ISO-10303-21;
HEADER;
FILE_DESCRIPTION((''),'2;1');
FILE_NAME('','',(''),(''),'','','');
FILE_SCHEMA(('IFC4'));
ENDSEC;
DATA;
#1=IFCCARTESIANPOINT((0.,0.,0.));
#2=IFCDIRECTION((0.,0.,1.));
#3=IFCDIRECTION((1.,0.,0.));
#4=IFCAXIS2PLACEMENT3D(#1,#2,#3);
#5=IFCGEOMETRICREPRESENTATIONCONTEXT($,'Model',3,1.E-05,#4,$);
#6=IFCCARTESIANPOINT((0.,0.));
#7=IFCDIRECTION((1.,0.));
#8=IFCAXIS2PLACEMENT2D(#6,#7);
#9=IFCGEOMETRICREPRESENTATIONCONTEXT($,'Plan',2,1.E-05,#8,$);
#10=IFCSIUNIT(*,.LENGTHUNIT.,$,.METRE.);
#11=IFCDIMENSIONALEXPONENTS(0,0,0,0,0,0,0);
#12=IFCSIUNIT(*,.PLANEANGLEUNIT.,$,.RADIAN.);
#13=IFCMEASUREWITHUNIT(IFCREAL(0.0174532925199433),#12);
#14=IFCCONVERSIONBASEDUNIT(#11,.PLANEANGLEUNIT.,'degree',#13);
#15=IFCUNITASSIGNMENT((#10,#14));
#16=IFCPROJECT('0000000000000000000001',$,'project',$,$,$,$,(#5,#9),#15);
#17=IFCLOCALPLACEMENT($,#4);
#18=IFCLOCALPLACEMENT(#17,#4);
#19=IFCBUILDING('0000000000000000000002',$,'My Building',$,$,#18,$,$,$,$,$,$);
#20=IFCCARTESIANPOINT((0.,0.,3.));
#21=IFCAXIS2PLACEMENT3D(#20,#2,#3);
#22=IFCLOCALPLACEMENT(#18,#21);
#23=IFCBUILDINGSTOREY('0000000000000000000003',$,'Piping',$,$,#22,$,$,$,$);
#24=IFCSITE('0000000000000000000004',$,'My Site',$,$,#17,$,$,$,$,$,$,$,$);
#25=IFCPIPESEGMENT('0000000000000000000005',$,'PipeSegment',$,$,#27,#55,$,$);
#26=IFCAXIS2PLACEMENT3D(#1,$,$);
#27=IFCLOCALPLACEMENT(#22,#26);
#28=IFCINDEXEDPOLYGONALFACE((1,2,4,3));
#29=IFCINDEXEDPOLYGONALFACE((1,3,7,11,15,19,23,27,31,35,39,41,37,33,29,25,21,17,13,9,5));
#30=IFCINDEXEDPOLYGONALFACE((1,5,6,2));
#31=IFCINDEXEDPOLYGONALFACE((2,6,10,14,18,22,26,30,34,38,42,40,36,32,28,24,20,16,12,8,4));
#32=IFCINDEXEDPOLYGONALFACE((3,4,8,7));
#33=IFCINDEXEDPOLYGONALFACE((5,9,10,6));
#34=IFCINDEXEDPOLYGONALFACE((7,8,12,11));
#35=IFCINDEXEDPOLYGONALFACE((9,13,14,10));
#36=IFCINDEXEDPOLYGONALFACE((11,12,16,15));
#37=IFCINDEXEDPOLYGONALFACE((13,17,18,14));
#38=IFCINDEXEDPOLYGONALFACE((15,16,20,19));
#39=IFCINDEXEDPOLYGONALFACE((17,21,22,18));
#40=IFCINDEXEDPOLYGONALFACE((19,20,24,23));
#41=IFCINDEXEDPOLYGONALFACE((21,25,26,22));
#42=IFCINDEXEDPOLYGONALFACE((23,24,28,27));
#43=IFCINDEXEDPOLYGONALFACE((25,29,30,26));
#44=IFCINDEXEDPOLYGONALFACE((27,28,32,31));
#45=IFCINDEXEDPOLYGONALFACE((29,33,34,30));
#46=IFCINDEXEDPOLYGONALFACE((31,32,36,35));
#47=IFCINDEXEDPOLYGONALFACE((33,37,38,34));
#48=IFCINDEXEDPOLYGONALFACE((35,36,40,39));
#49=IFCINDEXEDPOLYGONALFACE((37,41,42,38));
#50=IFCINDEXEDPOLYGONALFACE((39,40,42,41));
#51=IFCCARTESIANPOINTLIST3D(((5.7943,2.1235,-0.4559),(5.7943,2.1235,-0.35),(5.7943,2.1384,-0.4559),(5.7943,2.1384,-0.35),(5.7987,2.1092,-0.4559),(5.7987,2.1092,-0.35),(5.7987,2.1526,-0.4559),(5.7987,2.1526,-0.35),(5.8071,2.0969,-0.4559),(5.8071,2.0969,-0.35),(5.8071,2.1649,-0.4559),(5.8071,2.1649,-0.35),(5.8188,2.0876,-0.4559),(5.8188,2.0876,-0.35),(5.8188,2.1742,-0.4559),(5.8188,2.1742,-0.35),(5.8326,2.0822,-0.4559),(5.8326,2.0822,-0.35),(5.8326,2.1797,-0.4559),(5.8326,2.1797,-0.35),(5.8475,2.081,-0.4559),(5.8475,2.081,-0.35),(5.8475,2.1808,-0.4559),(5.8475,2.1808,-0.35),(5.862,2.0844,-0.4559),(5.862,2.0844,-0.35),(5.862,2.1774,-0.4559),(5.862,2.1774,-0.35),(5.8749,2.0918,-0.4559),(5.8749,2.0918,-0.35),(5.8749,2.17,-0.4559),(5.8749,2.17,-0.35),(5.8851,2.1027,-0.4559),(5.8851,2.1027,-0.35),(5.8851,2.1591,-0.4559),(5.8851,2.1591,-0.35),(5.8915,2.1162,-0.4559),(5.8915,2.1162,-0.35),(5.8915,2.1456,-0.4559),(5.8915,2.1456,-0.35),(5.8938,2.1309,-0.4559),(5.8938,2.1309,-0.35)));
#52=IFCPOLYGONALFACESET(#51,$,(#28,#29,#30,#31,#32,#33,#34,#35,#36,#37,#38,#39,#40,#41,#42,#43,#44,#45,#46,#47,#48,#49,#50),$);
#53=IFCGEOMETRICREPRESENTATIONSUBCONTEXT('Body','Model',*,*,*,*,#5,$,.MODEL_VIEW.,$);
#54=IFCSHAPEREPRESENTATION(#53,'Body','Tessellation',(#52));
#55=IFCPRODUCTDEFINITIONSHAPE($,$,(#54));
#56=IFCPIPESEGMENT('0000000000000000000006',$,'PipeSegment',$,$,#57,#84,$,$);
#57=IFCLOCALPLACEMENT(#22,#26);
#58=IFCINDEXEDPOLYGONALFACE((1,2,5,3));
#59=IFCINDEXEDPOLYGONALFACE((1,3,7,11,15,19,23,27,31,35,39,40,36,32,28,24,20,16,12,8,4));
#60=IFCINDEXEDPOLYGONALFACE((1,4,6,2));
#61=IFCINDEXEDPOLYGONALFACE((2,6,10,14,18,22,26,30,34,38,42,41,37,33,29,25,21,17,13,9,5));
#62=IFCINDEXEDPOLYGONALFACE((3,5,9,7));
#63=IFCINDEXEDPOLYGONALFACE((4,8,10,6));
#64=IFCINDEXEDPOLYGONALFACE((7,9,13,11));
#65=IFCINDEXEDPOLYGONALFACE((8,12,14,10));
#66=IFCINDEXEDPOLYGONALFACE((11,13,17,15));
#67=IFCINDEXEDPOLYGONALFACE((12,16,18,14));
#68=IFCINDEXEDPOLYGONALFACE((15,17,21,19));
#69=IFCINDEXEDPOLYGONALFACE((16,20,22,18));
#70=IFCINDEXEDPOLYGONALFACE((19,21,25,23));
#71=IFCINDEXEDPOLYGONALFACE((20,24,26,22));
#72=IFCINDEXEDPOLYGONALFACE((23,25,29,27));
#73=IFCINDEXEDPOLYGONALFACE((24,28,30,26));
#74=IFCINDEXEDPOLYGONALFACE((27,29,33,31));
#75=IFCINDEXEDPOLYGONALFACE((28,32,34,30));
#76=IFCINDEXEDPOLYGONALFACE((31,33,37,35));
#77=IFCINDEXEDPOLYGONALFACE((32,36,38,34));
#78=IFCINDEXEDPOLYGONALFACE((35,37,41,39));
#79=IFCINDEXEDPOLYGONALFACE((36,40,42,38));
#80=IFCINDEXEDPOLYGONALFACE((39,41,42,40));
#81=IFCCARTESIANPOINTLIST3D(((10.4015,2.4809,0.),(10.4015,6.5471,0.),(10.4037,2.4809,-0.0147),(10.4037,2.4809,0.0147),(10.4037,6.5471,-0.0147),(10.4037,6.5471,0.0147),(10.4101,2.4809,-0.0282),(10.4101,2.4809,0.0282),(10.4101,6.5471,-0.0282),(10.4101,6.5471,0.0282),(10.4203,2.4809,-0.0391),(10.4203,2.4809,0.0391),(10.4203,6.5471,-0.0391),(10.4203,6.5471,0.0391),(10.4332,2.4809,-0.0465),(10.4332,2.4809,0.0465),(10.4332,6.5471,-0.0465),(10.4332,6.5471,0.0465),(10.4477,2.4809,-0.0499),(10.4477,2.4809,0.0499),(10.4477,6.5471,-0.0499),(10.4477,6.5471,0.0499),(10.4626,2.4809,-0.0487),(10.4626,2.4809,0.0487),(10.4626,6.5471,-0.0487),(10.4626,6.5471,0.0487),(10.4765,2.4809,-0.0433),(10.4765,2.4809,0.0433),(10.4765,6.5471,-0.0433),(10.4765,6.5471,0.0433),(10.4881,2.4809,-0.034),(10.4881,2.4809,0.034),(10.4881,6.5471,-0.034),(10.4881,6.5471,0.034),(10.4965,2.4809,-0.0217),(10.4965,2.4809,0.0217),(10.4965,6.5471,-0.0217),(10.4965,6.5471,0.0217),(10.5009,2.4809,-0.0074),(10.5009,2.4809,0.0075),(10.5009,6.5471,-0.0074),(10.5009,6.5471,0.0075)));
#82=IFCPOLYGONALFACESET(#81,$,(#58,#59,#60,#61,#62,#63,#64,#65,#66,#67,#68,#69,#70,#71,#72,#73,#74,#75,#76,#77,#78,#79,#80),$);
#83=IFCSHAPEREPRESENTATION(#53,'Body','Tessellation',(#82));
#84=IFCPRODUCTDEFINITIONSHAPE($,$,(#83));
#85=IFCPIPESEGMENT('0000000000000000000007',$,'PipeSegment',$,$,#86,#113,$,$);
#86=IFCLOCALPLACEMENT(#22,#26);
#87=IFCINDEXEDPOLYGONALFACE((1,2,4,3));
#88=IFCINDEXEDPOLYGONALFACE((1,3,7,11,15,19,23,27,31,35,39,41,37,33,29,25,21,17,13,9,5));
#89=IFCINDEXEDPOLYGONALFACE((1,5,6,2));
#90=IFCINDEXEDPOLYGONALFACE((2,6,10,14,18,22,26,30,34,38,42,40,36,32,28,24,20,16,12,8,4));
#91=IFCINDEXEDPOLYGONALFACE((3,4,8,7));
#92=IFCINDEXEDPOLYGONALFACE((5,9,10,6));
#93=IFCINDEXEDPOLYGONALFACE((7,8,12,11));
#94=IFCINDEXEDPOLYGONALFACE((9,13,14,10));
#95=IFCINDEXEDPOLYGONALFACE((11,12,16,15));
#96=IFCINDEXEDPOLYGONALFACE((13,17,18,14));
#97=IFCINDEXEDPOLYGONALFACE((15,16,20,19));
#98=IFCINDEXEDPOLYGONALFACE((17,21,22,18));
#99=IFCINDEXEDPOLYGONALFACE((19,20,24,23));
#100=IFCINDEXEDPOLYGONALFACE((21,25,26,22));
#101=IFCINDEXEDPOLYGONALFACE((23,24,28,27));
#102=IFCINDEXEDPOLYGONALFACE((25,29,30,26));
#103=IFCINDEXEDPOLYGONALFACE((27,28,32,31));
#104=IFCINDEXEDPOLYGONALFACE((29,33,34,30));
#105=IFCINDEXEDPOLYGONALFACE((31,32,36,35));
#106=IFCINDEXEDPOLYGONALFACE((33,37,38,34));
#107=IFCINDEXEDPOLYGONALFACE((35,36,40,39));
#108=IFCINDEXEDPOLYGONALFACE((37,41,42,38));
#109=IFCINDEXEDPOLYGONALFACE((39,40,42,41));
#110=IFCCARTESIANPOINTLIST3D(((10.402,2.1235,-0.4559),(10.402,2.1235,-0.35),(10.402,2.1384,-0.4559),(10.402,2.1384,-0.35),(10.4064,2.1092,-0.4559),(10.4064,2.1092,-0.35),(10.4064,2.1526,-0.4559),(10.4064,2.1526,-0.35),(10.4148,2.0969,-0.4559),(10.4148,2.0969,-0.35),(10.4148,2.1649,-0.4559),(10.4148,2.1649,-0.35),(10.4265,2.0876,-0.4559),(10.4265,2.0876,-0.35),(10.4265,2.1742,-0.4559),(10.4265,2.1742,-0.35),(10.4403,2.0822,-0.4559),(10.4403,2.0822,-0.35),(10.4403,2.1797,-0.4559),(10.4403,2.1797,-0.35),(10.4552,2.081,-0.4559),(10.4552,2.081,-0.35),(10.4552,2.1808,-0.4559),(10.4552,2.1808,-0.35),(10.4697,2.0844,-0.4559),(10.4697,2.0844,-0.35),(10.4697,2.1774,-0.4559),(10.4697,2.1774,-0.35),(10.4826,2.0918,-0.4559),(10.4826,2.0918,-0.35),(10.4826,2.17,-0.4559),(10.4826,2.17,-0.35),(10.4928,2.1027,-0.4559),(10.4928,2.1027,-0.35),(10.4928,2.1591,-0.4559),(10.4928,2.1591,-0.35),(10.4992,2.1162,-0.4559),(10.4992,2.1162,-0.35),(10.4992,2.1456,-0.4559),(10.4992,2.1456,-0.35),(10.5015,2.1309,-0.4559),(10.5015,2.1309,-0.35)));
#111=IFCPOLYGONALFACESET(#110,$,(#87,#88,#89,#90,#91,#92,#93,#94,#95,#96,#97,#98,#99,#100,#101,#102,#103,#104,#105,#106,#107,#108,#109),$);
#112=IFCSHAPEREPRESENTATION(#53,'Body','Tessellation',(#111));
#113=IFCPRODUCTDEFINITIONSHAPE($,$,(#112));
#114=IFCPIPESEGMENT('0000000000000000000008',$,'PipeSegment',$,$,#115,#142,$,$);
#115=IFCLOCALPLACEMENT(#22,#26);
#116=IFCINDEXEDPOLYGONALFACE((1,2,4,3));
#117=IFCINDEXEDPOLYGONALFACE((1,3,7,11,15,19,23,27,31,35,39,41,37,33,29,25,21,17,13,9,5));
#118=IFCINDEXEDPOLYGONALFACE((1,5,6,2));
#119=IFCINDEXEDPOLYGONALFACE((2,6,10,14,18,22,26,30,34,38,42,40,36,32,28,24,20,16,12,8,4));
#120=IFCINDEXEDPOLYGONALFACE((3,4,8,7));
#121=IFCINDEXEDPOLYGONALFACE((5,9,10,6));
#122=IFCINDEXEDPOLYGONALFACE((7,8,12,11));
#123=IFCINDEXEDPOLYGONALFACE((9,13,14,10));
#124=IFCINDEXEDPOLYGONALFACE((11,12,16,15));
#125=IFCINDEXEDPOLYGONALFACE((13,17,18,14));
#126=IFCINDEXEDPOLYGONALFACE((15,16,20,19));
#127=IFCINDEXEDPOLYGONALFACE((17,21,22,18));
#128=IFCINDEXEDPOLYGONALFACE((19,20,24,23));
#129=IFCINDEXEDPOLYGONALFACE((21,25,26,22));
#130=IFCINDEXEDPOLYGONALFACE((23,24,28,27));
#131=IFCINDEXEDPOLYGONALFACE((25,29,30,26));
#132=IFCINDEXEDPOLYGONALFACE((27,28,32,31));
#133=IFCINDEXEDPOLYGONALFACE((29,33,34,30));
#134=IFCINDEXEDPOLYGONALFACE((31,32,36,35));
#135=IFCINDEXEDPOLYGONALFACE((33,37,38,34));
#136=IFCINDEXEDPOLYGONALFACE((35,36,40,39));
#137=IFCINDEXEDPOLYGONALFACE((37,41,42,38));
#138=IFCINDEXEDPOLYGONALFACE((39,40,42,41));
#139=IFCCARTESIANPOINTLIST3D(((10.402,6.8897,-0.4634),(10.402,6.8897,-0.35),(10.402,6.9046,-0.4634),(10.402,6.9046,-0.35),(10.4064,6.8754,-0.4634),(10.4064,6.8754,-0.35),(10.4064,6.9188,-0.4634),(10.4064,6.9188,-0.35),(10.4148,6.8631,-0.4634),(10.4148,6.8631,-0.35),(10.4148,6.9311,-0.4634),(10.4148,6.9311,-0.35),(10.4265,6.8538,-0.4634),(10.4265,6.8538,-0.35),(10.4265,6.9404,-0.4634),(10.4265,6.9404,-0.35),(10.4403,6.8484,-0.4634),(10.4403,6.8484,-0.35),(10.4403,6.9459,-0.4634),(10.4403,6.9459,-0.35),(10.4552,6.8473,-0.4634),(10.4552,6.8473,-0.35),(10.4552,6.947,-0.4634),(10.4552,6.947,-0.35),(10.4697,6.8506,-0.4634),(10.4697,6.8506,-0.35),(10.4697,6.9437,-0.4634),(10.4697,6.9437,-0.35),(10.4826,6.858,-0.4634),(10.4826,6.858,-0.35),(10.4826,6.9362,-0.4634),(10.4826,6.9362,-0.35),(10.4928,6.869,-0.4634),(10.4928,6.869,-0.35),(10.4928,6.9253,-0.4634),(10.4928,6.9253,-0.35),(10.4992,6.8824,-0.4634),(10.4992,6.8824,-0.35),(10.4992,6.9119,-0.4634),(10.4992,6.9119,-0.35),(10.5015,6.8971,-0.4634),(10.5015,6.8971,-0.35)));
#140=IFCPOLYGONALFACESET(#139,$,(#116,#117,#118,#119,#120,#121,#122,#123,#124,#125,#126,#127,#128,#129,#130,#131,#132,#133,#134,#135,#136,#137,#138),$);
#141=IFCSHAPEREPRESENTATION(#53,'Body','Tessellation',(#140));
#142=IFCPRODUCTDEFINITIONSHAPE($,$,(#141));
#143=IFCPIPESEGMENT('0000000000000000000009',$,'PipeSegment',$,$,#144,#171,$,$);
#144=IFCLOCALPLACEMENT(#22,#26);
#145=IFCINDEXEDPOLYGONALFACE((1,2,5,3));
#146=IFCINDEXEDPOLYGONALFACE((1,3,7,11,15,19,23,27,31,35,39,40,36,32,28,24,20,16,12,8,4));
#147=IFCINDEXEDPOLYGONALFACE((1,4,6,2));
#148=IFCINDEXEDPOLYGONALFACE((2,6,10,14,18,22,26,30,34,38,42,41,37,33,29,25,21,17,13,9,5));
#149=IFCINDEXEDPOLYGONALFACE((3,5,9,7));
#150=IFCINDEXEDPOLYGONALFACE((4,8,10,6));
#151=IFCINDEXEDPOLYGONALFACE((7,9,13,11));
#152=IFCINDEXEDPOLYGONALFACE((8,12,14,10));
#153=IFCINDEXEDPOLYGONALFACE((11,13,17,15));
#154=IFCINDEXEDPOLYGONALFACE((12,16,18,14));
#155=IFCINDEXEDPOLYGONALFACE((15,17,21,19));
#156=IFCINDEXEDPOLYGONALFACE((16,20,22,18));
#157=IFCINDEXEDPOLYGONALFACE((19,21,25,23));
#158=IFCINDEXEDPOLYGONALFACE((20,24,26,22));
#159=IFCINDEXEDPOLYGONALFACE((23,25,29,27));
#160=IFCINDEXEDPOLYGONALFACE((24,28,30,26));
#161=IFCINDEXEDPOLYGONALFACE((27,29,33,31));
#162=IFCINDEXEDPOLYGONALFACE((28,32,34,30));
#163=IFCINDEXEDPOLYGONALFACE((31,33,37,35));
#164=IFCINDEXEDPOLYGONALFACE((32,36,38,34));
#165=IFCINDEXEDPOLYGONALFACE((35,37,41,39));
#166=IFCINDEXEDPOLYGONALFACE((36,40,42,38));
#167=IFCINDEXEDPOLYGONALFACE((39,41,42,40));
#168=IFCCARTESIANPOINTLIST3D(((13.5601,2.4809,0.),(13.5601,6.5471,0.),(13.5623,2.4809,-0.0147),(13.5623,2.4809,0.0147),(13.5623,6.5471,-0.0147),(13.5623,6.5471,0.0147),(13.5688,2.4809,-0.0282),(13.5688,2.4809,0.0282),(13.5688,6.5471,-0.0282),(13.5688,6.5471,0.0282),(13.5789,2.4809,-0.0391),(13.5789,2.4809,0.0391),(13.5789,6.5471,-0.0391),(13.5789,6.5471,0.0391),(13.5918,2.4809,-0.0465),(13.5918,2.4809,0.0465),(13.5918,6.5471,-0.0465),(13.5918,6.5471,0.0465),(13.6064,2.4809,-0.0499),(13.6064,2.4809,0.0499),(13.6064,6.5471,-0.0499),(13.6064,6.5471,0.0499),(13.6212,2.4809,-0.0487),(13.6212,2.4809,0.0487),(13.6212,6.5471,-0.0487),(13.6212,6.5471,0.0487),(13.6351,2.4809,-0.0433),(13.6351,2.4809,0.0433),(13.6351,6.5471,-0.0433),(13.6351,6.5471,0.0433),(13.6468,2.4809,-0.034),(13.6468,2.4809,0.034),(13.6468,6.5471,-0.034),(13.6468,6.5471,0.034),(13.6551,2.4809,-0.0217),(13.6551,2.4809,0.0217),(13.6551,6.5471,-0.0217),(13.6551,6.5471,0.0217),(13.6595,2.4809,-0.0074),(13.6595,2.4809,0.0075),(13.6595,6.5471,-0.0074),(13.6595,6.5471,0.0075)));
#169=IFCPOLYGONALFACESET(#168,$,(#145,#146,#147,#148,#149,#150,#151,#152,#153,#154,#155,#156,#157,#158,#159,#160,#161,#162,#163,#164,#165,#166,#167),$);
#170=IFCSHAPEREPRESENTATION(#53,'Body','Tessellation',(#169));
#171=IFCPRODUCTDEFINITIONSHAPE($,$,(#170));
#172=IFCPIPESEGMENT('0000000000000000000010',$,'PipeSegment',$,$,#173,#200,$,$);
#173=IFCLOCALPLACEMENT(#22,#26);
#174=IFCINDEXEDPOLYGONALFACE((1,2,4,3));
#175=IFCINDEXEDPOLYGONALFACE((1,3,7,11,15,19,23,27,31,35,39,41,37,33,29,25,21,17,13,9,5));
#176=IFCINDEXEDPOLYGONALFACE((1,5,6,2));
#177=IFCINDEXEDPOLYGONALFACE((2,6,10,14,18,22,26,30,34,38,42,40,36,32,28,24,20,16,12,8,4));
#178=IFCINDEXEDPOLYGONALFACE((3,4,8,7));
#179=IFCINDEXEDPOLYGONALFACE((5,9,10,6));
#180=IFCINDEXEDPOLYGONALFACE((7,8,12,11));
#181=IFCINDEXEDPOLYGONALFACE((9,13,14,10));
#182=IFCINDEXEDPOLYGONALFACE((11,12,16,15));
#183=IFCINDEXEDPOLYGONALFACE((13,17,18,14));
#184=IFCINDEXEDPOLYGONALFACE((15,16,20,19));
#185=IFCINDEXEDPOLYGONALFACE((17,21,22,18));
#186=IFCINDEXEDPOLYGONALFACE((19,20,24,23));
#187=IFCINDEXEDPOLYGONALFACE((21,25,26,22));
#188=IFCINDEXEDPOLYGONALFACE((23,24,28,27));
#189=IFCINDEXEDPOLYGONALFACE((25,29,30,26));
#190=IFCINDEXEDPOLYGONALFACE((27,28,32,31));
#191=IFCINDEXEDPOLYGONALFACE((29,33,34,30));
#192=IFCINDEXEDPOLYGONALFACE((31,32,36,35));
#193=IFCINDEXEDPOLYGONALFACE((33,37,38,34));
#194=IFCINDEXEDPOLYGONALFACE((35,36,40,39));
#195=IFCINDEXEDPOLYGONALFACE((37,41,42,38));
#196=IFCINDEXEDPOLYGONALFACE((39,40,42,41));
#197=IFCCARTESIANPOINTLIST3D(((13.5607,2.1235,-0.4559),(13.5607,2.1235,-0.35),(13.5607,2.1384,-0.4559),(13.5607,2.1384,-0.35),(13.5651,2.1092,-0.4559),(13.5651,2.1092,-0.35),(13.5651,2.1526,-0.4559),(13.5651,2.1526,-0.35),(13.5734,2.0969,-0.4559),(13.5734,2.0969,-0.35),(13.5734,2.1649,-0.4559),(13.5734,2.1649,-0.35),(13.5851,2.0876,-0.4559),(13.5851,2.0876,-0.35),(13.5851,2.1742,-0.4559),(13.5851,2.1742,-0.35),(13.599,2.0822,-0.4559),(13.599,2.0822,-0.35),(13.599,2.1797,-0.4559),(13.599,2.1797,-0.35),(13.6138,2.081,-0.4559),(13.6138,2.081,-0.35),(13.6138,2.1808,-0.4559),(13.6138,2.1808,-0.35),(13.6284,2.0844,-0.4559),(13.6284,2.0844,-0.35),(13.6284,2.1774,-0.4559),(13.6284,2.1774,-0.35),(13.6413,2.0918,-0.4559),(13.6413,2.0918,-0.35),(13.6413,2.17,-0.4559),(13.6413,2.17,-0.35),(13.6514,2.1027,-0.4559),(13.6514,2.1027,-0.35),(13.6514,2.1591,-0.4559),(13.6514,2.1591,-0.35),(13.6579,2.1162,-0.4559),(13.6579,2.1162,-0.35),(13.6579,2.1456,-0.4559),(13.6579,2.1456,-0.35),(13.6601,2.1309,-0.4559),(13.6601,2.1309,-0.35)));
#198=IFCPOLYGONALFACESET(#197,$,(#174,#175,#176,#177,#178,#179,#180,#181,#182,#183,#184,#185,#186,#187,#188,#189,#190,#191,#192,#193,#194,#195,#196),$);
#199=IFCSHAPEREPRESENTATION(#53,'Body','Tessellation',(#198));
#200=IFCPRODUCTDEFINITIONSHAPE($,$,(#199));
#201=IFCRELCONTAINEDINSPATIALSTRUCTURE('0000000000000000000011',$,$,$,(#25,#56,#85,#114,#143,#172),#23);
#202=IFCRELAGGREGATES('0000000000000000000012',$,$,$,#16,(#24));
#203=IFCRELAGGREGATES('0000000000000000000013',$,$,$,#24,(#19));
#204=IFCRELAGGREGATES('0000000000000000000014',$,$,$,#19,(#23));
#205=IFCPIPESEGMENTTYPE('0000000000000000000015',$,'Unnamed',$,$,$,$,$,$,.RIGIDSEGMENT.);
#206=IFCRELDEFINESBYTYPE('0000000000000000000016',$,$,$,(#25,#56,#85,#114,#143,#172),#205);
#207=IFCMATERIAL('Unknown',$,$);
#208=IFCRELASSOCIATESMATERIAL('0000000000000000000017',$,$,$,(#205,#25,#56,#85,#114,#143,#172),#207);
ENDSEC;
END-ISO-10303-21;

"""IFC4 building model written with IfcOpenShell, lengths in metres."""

from ifc_helpers import new_model, entity, si_unit, converted_unit, frame, origin_with_axes, origin_2d_with_axis, place, context, subcontext, project, spatial, circle, extrude, material, material_profile, profile_set, profile_usage, type_object, element, save


model = new_model("IFC4")

# Units and contexts
model_context = context("Model", 3, precision=1e-05, world=origin_with_axes())
plan_context = context("Plan", 2, precision=1e-05, world=origin_2d_with_axis())
body_context = subcontext(model_context, "Body", "Model", "MODEL_VIEW")
ifc_project = project(units=[si_unit("LENGTHUNIT", "METRE"), converted_unit("PLANEANGLEUNIT", "degree", entity("IfcReal", 0.0174532925199433), si_unit("PLANEANGLEUNIT", "RADIAN"), dimensions=[0, 0, 0, 0, 0, 0, 0])], contexts=[model_context, plan_context])

# Site, building, storey
site_placement = place(None, origin_with_axes())
site = spatial("IfcSite", under=ifc_project, at=site_placement, Name="My Site")
building_placement = place(site_placement, origin_with_axes())
building = spatial("IfcBuilding", under=site, at=building_placement, Name="My Building")
storey_placement = place(building_placement, frame((0.0, 0.0, 3.0), z_axis=(0.0, 0.0, 1.0), x_axis=(1.0, 0.0, 0.0)))
storey = spatial("IfcBuildingStorey", under=building, at=storey_placement, Name="Piping")

# Pipe segments
ifc_material = material(Name="Unknown")
ifc_material_profile = material_profile(ifc_material, circle(Radius=0.05))
ifc_profile_set = profile_set([ifc_material_profile])
pipe_segment_type = type_object("IfcPipeSegmentType", Name="Unnamed", PredefinedType="RIGIDSEGMENT", material=ifc_profile_set)
ifc_profile_usage_1 = profile_usage(ifc_profile_set, cardinal=5)
pipe_segment_1_placement = place(storey_placement, frame((5.8438, 2.1309, -0.35), z_axis=(0.0, 0.0, -1.0), x_axis=(1.0, 0.0, 0.0)))
element("IfcPipeSegment", 1, at=pipe_segment_1_placement, inside=storey, type_object=pipe_segment_type, material=ifc_profile_usage_1, Name="PipeSegment", context=body_context, shape_type="SweptSolid", body=[
    extrude(circle(Radius=0.05), origin_with_axes(), (0.0, 0.0, 1.0), 0.1059),
])
ifc_profile_usage_2 = profile_usage(ifc_profile_set, cardinal=5)
pipe_segment_2_placement = place(storey_placement, frame((10.4515, 2.4809, 0.0), z_axis=(0.0, 1.0, 0.0), x_axis=(-1.0, 0.0, 0.0)))
element("IfcPipeSegment", 2, at=pipe_segment_2_placement, inside=storey, type_object=pipe_segment_type, material=ifc_profile_usage_2, Name="PipeSegment", context=body_context, shape_type="SweptSolid", body=[
    extrude(circle(Radius=0.05), origin_with_axes(), (0.0, 0.0, 1.0), 4.0662),
])
ifc_profile_usage_3 = profile_usage(ifc_profile_set, cardinal=5)
pipe_segment_3_placement = place(storey_placement, frame((10.4515, 2.1309, -0.35), z_axis=(0.0, 0.0, -1.0), x_axis=(1.0, 0.0, 0.0)))
element("IfcPipeSegment", 3, at=pipe_segment_3_placement, inside=storey, type_object=pipe_segment_type, material=ifc_profile_usage_3, Name="PipeSegment", context=body_context, shape_type="SweptSolid", body=[
    extrude(circle(Radius=0.05), origin_with_axes(), (0.0, 0.0, 1.0), 0.1059),
])
ifc_profile_usage_4 = profile_usage(ifc_profile_set, cardinal=5)
pipe_segment_4_placement = place(storey_placement, frame((10.4515, 6.8971, -0.35), z_axis=(0.0, 0.0, -1.0), x_axis=(1.0, 0.0, 0.0)))
element("IfcPipeSegment", 4, at=pipe_segment_4_placement, inside=storey, type_object=pipe_segment_type, material=ifc_profile_usage_4, Name="PipeSegment", context=body_context, shape_type="SweptSolid", body=[
    extrude(circle(Radius=0.05), origin_with_axes(), (0.0, 0.0, 1.0), 0.1134),
])
ifc_profile_usage_5 = profile_usage(ifc_profile_set, cardinal=5)
pipe_segment_5_placement = place(storey_placement, frame((13.6101, 2.4809, 0.0), z_axis=(0.0, 1.0, 0.0), x_axis=(-1.0, 0.0, 0.0)))
element("IfcPipeSegment", 5, at=pipe_segment_5_placement, inside=storey, type_object=pipe_segment_type, material=ifc_profile_usage_5, Name="PipeSegment", context=body_context, shape_type="SweptSolid", body=[
    extrude(circle(Radius=0.05), origin_with_axes(), (0.0, 0.0, 1.0), 4.0662),
])
ifc_profile_usage_6 = profile_usage(ifc_profile_set, cardinal=5)
pipe_segment_6_placement = place(storey_placement, frame((13.6101, 2.1309, -0.35), z_axis=(0.0, 0.0, -1.0), x_axis=(1.0, 0.0, 0.0)))
element("IfcPipeSegment", 6, at=pipe_segment_6_placement, inside=storey, type_object=pipe_segment_type, material=ifc_profile_usage_6, Name="PipeSegment", context=body_context, shape_type="SweptSolid", body=[
    extrude(circle(Radius=0.05), origin_with_axes(), (0.0, 0.0, 1.0), 0.1059),
])

save(model, "model.ifc")
